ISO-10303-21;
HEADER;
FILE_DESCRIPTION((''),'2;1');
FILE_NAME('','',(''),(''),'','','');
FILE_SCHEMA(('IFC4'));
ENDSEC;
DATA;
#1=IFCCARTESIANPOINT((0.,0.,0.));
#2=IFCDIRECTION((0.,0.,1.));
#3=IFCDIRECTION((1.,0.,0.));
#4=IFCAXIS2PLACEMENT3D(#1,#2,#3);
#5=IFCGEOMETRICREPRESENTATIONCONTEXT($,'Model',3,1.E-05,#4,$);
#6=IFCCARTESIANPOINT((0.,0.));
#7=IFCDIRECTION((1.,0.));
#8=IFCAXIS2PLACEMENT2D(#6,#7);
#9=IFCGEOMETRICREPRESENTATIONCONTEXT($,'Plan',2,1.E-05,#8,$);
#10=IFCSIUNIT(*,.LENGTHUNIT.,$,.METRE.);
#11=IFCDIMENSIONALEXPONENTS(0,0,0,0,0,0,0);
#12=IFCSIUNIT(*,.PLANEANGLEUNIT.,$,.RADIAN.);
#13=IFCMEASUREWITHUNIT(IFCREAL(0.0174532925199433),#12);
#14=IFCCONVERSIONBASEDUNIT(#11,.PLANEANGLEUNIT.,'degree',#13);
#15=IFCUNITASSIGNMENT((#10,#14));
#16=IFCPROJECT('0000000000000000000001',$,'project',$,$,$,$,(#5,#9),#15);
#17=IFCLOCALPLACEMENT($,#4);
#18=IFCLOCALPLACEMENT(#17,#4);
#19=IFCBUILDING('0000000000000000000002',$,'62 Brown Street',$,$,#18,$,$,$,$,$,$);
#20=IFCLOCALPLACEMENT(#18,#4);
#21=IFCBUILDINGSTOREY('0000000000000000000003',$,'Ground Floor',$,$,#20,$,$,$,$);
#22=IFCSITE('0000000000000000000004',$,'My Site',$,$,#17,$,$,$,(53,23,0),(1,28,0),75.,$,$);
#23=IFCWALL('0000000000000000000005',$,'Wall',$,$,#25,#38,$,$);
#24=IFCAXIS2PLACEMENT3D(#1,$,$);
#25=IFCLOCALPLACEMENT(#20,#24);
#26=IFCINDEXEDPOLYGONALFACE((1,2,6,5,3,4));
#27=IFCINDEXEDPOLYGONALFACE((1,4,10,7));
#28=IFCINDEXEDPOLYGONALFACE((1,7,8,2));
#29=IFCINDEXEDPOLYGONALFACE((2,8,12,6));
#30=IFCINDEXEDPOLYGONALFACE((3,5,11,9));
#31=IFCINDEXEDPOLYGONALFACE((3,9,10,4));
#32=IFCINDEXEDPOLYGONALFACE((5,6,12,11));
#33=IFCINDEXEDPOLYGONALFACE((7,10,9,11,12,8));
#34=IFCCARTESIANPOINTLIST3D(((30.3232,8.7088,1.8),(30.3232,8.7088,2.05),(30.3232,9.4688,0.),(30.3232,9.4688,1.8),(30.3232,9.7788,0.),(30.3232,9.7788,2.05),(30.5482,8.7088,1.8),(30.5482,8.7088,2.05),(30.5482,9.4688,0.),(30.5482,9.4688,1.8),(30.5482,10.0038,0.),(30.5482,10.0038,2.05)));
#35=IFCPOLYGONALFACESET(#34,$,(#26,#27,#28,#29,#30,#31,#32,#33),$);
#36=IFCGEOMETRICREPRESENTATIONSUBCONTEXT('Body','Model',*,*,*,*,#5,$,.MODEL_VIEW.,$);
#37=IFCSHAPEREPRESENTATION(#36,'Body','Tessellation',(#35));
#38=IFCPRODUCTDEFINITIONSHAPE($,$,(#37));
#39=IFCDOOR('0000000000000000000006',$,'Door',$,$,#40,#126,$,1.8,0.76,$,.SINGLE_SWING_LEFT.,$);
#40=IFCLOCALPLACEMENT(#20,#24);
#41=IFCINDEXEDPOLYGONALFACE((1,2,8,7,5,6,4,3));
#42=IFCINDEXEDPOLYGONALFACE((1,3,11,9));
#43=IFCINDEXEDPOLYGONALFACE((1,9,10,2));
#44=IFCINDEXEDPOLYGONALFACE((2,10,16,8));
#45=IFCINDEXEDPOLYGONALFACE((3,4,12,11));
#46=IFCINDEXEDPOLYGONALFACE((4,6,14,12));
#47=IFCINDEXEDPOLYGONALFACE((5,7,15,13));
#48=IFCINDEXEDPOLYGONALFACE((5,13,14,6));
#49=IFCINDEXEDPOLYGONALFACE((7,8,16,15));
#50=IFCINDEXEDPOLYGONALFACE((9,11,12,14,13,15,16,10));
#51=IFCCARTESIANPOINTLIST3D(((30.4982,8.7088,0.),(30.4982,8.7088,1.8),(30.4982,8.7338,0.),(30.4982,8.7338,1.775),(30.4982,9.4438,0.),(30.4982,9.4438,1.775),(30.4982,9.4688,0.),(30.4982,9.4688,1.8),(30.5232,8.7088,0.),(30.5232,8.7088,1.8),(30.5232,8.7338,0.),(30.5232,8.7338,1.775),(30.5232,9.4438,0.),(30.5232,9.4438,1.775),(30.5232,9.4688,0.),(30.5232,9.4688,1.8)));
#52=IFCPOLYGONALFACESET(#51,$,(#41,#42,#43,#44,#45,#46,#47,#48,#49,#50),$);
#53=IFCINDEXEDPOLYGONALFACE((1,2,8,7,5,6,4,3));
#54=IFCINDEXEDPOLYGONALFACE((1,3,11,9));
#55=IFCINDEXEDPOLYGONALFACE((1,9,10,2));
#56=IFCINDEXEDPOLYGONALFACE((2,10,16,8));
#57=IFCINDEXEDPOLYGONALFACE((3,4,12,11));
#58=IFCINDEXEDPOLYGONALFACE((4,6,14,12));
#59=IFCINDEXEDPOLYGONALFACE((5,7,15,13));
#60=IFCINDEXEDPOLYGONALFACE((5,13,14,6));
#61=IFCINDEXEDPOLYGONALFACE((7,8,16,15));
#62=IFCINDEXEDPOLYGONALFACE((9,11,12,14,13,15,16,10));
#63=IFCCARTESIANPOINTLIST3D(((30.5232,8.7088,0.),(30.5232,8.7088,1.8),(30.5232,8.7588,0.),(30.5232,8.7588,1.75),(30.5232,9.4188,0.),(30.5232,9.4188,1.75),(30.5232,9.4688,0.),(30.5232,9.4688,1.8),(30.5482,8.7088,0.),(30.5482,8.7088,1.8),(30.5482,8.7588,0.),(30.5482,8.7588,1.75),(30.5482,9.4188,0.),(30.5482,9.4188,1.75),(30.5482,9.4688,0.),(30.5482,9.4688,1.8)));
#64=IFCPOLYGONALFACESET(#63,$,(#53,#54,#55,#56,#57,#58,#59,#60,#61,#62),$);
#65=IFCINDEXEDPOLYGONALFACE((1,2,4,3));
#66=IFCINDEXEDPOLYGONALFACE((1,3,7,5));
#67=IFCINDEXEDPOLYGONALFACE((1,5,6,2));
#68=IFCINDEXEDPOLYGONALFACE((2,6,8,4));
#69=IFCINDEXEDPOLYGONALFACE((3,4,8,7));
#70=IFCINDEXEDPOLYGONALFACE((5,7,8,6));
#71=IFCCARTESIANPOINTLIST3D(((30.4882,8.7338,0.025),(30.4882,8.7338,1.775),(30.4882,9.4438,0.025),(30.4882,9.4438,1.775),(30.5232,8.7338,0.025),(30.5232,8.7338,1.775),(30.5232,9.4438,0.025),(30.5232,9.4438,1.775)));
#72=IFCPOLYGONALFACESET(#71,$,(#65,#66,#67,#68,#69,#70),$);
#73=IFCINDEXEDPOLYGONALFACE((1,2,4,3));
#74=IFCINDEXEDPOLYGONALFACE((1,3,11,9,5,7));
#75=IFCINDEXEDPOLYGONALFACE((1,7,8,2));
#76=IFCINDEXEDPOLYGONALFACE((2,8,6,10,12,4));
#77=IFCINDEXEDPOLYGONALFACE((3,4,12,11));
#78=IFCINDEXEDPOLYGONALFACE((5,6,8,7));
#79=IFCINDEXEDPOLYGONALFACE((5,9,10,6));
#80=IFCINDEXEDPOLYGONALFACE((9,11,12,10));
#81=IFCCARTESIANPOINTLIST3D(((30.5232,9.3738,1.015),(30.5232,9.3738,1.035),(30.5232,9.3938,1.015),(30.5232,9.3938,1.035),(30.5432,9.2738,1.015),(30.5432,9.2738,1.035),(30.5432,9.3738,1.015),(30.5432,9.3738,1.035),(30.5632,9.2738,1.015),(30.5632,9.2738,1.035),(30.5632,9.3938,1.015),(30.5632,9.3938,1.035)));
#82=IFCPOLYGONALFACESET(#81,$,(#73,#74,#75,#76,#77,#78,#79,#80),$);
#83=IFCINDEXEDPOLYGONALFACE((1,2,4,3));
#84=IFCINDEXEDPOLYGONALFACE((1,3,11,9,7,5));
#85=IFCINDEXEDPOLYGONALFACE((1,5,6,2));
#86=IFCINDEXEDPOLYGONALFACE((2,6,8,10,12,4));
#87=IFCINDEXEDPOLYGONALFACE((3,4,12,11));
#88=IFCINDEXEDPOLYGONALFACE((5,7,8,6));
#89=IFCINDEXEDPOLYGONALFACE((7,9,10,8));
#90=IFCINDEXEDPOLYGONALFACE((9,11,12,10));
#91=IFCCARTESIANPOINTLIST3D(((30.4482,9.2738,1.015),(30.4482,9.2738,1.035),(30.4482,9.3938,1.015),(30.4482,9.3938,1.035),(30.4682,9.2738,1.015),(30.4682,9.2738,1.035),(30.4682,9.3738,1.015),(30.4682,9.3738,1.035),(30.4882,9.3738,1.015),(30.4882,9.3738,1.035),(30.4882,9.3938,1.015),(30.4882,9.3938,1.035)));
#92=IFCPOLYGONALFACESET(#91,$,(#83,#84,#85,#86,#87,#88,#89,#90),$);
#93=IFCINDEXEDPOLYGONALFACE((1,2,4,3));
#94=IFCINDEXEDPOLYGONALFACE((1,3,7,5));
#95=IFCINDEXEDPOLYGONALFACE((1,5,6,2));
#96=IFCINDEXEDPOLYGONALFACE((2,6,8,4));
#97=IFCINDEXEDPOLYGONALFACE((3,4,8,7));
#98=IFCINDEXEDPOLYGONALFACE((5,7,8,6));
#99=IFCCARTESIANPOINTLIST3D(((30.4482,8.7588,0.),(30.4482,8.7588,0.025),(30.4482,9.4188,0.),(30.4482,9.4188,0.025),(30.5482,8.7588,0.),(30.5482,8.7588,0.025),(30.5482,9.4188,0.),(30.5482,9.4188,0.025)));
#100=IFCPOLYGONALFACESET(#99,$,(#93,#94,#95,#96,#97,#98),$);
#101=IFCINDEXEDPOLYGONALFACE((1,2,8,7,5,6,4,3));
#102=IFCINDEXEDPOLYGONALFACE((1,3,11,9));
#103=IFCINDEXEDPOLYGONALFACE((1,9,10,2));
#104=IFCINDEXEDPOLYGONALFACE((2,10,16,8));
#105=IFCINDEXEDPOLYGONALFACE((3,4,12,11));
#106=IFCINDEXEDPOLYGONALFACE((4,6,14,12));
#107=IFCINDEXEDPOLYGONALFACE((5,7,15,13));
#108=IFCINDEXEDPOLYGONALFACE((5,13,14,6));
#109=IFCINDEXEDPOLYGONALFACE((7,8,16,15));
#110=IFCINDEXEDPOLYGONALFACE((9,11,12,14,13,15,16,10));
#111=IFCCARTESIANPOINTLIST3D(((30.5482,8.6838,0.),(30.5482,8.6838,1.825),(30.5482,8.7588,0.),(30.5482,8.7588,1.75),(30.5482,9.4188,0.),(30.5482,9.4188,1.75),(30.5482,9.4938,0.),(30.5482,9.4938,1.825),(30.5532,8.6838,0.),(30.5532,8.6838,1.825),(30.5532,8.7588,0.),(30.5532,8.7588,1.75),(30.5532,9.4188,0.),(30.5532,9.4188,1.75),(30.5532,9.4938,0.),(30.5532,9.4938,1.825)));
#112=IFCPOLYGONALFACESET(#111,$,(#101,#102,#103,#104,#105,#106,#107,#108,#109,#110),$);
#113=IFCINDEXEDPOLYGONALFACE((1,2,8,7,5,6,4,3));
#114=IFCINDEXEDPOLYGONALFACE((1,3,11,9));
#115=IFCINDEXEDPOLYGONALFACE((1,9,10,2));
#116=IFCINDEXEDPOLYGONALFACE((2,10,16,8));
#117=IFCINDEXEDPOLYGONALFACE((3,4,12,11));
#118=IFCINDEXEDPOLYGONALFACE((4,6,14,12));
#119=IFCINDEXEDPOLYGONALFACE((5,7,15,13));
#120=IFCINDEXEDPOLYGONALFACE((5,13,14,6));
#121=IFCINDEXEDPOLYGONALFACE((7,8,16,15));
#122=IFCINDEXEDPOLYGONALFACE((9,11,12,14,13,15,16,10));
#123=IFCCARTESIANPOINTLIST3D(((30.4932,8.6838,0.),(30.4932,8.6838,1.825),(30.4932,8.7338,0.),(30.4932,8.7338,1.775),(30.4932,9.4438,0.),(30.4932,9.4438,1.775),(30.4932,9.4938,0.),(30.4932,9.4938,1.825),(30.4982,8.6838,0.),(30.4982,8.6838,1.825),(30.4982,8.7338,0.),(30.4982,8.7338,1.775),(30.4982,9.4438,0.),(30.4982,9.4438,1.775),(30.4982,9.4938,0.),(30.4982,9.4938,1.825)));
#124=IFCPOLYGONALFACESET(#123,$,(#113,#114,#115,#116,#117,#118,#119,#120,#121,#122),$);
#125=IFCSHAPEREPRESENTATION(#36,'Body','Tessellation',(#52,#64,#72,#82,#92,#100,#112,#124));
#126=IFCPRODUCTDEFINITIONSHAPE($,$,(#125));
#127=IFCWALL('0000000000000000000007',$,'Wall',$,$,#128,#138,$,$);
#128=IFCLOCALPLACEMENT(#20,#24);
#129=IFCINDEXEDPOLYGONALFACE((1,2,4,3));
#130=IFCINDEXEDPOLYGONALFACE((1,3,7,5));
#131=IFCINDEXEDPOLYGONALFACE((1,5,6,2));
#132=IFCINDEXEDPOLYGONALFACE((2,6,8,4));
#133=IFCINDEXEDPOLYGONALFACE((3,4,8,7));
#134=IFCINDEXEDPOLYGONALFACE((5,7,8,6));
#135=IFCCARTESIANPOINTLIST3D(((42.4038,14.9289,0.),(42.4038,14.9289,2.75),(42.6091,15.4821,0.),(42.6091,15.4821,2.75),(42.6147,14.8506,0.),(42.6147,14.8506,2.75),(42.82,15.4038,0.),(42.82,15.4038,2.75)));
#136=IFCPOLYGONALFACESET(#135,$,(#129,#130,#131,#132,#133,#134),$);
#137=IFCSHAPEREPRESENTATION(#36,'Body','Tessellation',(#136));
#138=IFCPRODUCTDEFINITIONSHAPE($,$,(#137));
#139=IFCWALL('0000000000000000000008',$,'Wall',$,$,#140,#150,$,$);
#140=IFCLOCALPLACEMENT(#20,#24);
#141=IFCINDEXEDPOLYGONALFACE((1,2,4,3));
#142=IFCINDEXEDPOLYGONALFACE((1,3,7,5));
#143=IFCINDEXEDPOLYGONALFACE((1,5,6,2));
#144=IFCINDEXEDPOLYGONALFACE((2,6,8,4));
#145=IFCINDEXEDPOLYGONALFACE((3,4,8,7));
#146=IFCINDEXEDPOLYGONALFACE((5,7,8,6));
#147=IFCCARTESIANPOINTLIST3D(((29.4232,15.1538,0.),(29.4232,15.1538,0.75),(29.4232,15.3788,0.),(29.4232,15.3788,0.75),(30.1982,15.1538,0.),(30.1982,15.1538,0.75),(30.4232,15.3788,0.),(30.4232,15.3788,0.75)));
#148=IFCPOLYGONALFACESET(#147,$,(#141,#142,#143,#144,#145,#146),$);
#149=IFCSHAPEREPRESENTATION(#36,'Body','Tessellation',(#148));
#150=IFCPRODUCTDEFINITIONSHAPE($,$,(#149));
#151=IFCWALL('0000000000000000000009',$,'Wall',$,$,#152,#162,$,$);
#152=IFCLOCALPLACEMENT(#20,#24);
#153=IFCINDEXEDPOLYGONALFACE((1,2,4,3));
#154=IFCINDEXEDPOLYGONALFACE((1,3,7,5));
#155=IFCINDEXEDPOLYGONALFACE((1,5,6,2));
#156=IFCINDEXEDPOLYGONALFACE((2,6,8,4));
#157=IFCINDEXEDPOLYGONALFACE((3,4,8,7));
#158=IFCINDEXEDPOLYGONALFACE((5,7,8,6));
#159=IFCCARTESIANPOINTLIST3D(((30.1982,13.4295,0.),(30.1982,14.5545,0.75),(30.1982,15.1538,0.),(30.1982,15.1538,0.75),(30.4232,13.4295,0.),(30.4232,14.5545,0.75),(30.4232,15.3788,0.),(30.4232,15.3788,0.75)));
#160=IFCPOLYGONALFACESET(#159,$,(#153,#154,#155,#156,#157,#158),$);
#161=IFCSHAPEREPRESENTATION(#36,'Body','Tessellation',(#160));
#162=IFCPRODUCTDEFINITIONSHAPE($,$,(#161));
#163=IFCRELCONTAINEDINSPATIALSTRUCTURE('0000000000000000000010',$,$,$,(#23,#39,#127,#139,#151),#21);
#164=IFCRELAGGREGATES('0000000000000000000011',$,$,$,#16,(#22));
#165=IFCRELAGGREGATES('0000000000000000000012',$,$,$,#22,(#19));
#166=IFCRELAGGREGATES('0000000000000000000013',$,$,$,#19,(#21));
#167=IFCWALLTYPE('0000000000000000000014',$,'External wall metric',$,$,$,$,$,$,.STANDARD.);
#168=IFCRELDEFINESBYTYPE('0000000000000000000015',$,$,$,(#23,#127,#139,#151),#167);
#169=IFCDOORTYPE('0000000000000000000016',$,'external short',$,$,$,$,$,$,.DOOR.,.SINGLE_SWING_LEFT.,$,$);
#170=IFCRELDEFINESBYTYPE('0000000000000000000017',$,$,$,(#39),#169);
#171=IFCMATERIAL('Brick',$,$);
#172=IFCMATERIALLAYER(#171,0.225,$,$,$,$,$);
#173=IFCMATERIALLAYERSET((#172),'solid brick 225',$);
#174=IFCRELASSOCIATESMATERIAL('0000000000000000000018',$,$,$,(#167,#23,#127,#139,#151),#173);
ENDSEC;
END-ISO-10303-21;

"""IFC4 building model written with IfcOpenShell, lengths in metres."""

from ifc_helpers import new_model, entity, si_unit, converted_unit, frame, origin_with_axes, origin_2d_with_axis, place, context, subcontext, project, spatial, line, indexed_curve, outline, extrude, clip, halfspace, shape, source, transform, mapped, material, layer, layer_set, layer_usage, type_object, type_shapes, element, fill, save


model = new_model("IFC4")

# Units and contexts
model_context = context("Model", 3, precision=1e-05, world=origin_with_axes())
plan_context = context("Plan", 2, precision=1e-05, world=origin_2d_with_axis())
body_context_1 = subcontext(model_context, "Body", "Model", "MODEL_VIEW")
body_context_2 = subcontext(plan_context, "Body", "Plan", "PLAN_VIEW")
ifc_project = project(units=[si_unit("LENGTHUNIT", "METRE"), converted_unit("PLANEANGLEUNIT", "degree", entity("IfcReal", 0.0174532925199433), si_unit("PLANEANGLEUNIT", "RADIAN"), dimensions=[0, 0, 0, 0, 0, 0, 0])], contexts=[model_context, plan_context])

# Site, building, storey
site_placement = place(None, origin_with_axes())
site = spatial("IfcSite", under=ifc_project, at=site_placement, Name="My Site", RefLatitude=(53, 23, 0), RefLongitude=(1, 28, 0), RefElevation=75.0)
building_placement = place(site_placement, origin_with_axes())
building = spatial("IfcBuilding", under=site, at=building_placement, Name="62 Brown Street")
storey_placement = place(building_placement, origin_with_axes())
storey = spatial("IfcBuildingStorey", under=building, at=storey_placement, Name="Ground Floor")

# Shared definitions
ifc_material_1 = material(Name="Brick")
ifc_layer_1 = layer(ifc_material_1, 0.225)
ifc_layer_set_1 = layer_set([ifc_layer_1], Name="solid brick 225")
wall_type_1 = type_object("IfcWallType", Name="External wall metric", PredefinedType="STANDARD", material=ifc_layer_set_1)

# Wall, opening, door
ifc_layer_usage_1 = layer_usage(ifc_layer_set_1, "AXIS2", "POSITIVE", 0.0)
wall_1_placement = place(storey_placement, frame((30.5482, 8.7088, 0.0), z_axis=(0.0, 0.0, 1.0), x_axis=(0.0, 1.0, 0.0)))
wall_1 = element("IfcWall", 1, at=wall_1_placement, inside=storey, type_object=wall_type_1, material=ifc_layer_usage_1, Name="Wall", context=body_context_1, shape_type="Clipping", body=[
    clip(extrude(outline(indexed_curve([(0.0, 0.0), (0.0, 0.225), (1.295, 0.225), (1.295, 0.0), (0.0, 0.0)], self_intersect=False)), origin_with_axes(), (0.0, 0.0, 1.0), 2.05), halfspace(frame((1.295, 0.0, 0.0), z_axis=(0.450001, 0.450001, 0.0), x_axis=(-0.225, 0.225, 0.0)), False)),
])
shared_shape_1 = source(origin_with_axes(), body_context_1, "Body", "SweptSolid", [
    extrude(outline(indexed_curve([(0.0, 0.0), (0.76, 0.0), (0.76, 1.8), (0.0, 1.8)], segments=[line(1, 2, 3, 4, 1)])), frame((0.0, -0.1, 0.0), z_axis=(0.0, -1.0, 0.0), x_axis=(1.0, 0.0, 0.0)), (0.0, 0.0, -1.0), 0.425),
])
opening_1_placement = place(wall_1_placement, frame((0.0, 0.0, 0.0), z_axis=(0.0, 0.0, 1.0), x_axis=(1.0, 0.0, 0.0)))
opening_1 = element("IfcOpeningElement", 2, at=opening_1_placement, cuts=wall_1, PredefinedType="OPENING", context=body_context_1, shape_type="MappedRepresentation", body=[
    mapped(shared_shape_1, transform((0.0, 0.0, 0.0), x_axis=(1.0, 0.0, 0.0), y_axis=(0.0, 1.0, 0.0), z_axis=(0.0, 0.0, 1.0), scale=1.0)),
])
door_type_1 = type_object("IfcDoorType", Name="external short", OperationType="SINGLE_SWING_LEFT", PredefinedType="DOOR")
shared_shape_2 = source(origin_with_axes(), body_context_1, "Body", "SweptSolid", [
    extrude(outline(indexed_curve([(0.0, 0.0), (0.0, 1.8), (0.76, 1.8), (0.76, 0.0), (0.735, 0.0), (0.735, 1.775), (0.025, 1.775), (0.025, 0.0)], segments=[line(1, 2, 3, 4, 5, 6, 7, 8, 1)])), frame((0.0, 0.025, 0.0), z_axis=(0.0, -1.0, 0.0), x_axis=(1.0, 0.0, 0.0)), (0.0, 0.0, -1.0), 0.025),
    extrude(outline(indexed_curve([(0.0, 0.0), (0.0, 1.8), (0.76, 1.8), (0.76, 0.0), (0.71, 0.0), (0.71, 1.75), (0.05, 1.75), (0.05, 0.0)], segments=[line(1, 2, 3, 4, 5, 6, 7, 8, 1)])), frame((0.0, 0.0, 0.0), z_axis=(0.0, -1.0, 0.0), x_axis=(1.0, 0.0, 0.0)), (0.0, 0.0, -1.0), 0.025),
    extrude(outline(indexed_curve([(0.0, 0.0), (0.71, 0.0), (0.71, 0.035), (0.0, 0.035)], segments=[line(1, 2, 3, 4, 1)])), frame((0.025, 0.025, 0.025), z_axis=(0.0, 0.0, 1.0), x_axis=(1.0, 0.0, 0.0)), (0.0, 0.0, 1.0), 1.75),
    extrude(outline(indexed_curve([(0.0, 0.0), (0.0, -0.04), (-0.12, -0.04), (-0.12, -0.02), (-0.02, -0.02), (-0.02, 0.0)], segments=[line(1, 2, 3, 4, 5, 6, 1)])), frame((0.685, 0.025, 1.015), z_axis=(0.0, 0.0, 1.0), x_axis=(1.0, 0.0, 0.0)), (0.0, 0.0, 1.0), 0.02),
    extrude(outline(indexed_curve([(0.0, 0.0), (0.0, 0.04), (-0.12, 0.04), (-0.12, 0.02), (-0.02, 0.02), (-0.02, 0.0)], segments=[line(1, 2, 3, 4, 5, 6, 1)])), frame((0.685, 0.06, 1.015), z_axis=(0.0, 0.0, 1.0), x_axis=(1.0, 0.0, 0.0)), (0.0, 0.0, 1.0), 0.02),
    extrude(outline(indexed_curve([(0.0, 0.0), (0.66, 0.0), (0.66, 0.1), (0.0, 0.1)], segments=[line(1, 2, 3, 4, 1)])), frame((0.05, 0.0, 0.0), z_axis=(0.0, 0.0, 1.0), x_axis=(1.0, 0.0, 0.0)), (0.0, 0.0, 1.0), 0.025),
    extrude(outline(indexed_curve([(0.0, 0.0), (0.0, 1.825), (0.81, 1.825), (0.81, 0.0), (0.735, 0.0), (0.735, 1.75), (0.075, 1.75), (0.075, 0.0)], segments=[line(1, 2, 3, 4, 5, 6, 7, 8, 1)])), frame((-0.025, -0.005, 0.0), z_axis=(0.0, -1.0, 0.0), x_axis=(1.0, 0.0, 0.0)), (0.0, 0.0, -1.0), 0.005),
    extrude(outline(indexed_curve([(0.0, 0.0), (0.0, 1.825), (0.81, 1.825), (0.81, 0.0), (0.76, 0.0), (0.76, 1.775), (0.05, 1.775), (0.05, 0.0)], segments=[line(1, 2, 3, 4, 5, 6, 7, 8, 1)])), frame((-0.025, 0.05, 0.0), z_axis=(0.0, -1.0, 0.0), x_axis=(1.0, 0.0, 0.0)), (0.0, 0.0, -1.0), 0.005),
])
shared_shape_3 = source(origin_with_axes(), body_context_2, "Body", "Curve2D", [
    entity("IfcIndexedPolyCurve", entity("IfcCartesianPointList2D", [[0.0, 0.0], [0.0, 0.05], [0.025, 0.05], [0.025, 0.025], [0.05, 0.025], [0.05, 0.0]]), [entity("IfcLineIndex", [1, 2, 3, 4, 5, 6, 1])]),
    entity("IfcIndexedPolyCurve", entity("IfcCartesianPointList2D", [[0.76, 0.0], [0.76, 0.05], [0.735, 0.05], [0.735, 0.025], [0.71, 0.025], [0.71, 0.0]]), [entity("IfcLineIndex", [1, 2, 3, 4, 5, 6, 1])]),
    entity("IfcTrimmedCurve", entity("IfcEllipse", entity("IfcAxis2Placement2D", entity("IfcCartesianPoint", [0.06, 0.05]), entity("IfcDirection", [1.0, 0.0])), 0.675, 0.71), [entity("IfcCartesianPoint", [0.735, 0.05])], [entity("IfcCartesianPoint", [0.06, 0.76])], True, "CARTESIAN"),
    entity("IfcIndexedPolyCurve", entity("IfcCartesianPointList2D", [[0.025, 0.05], [0.06, 0.05], [0.06, 0.76], [0.025, 0.76]]), [entity("IfcLineIndex", [1, 2, 3, 4, 1])]),
])
type_shapes(door_type_1, [shared_shape_2, shared_shape_3])
door_1_placement = place(opening_1_placement, frame((0.0, 0.0, 0.0), z_axis=(0.0, 0.0, 1.0), x_axis=(1.0, 0.0, 0.0)))
door_1 = element("IfcDoor", 3, at=door_1_placement, inside=storey, type_object=door_type_1, Name="Door", OperationType="SINGLE_SWING_LEFT", OverallHeight=1.8, OverallWidth=0.76, shapes=[
    shape(body_context_1, "Body", "MappedRepresentation", [mapped(shared_shape_2, transform((0.0, 0.0, 0.0), x_axis=(1.0, 0.0, 0.0), y_axis=(0.0, 1.0, 0.0), z_axis=(0.0, 0.0, 1.0), scale=1.0))]),
    shape(body_context_2, "Body", "MappedRepresentation", [mapped(shared_shape_3, transform((0.0, 0.0, 0.0), x_axis=(1.0, 0.0, 0.0), y_axis=(0.0, 1.0, 0.0), z_axis=(0.0, 0.0, 1.0), scale=1.0))]),
])
fill(opening_1, door_1)

# Walls
ifc_layer_usage_2 = layer_usage(ifc_layer_set_1, "AXIS2", "POSITIVE", 0.0)
wall_2_placement = place(storey_placement, frame((42.6147, 14.8506, 0.0), z_axis=(0.0, 0.0, 1.0), x_axis=(0.347944, 0.937515, 0.0)))
element("IfcWall", 4, at=wall_2_placement, inside=storey, type_object=wall_type_1, material=ifc_layer_usage_2, Name="Wall", context=body_context_1, shape_type="SweptSolid", body=[
    extrude(outline(indexed_curve([(0.0, 0.0), (0.0, 0.225), (0.5901, 0.225), (0.5901, 0.0), (0.0, 0.0)], self_intersect=False)), origin_with_axes(), (0.0, 0.0, 1.0), 2.75),
])
ifc_layer_usage_3 = layer_usage(ifc_layer_set_1, "AXIS2", "POSITIVE", 0.0)
wall_3_placement = place(storey_placement, frame((30.4232, 15.3788, 0.0), z_axis=(0.0, 0.0, 1.0), x_axis=(-1.0, 0.0, 0.0)))
element("IfcWall", 5, at=wall_3_placement, inside=storey, type_object=wall_type_1, material=ifc_layer_usage_3, Name="Wall", context=body_context_1, shape_type="Clipping", body=[
    clip(extrude(outline(indexed_curve([(0.0, 0.0), (0.0, 0.225), (1.0, 0.225), (1.0, 0.0), (0.0, 0.0)], self_intersect=False)), origin_with_axes(), (0.0, 0.0, 1.0), 0.75), halfspace(frame((0.0, 0.0, 0.0), z_axis=(-0.707107, 0.707107, 0.0), x_axis=(0.707107, 0.707107, 0.0)), False)),
])
ifc_layer_usage_4 = layer_usage(ifc_layer_set_1, "AXIS2", "POSITIVE", 0.0)
wall_4_placement = place(storey_placement, frame((30.4232, 13.4295, 0.0), z_axis=(0.0, 0.0, 1.0), x_axis=(0.0, 1.0, 0.0)))
element("IfcWall", 6, at=wall_4_placement, inside=storey, type_object=wall_type_1, material=ifc_layer_usage_4, Name="Wall", context=body_context_1, shape_type="Clipping", body=[
    clip(clip(extrude(outline(indexed_curve([(0.0, 0.0), (0.0, 0.225), (1.9493, 0.225), (1.9493, 0.0), (0.0, 0.0)], self_intersect=False)), origin_with_axes(), (0.0, 0.0, 1.0), 0.75), halfspace(frame((0.416, 0.5, 0.2774), z_axis=(-0.5547, 0.0, 0.83205), x_axis=(0.0, -1.0, 0.0)), False)), halfspace(frame((1.9493, 0.0, 0.0), z_axis=(0.707107, 0.707107, 0.0), x_axis=(0.707107, -0.707107, 0.0)), False)),
])

save(model, "model.ifc")
